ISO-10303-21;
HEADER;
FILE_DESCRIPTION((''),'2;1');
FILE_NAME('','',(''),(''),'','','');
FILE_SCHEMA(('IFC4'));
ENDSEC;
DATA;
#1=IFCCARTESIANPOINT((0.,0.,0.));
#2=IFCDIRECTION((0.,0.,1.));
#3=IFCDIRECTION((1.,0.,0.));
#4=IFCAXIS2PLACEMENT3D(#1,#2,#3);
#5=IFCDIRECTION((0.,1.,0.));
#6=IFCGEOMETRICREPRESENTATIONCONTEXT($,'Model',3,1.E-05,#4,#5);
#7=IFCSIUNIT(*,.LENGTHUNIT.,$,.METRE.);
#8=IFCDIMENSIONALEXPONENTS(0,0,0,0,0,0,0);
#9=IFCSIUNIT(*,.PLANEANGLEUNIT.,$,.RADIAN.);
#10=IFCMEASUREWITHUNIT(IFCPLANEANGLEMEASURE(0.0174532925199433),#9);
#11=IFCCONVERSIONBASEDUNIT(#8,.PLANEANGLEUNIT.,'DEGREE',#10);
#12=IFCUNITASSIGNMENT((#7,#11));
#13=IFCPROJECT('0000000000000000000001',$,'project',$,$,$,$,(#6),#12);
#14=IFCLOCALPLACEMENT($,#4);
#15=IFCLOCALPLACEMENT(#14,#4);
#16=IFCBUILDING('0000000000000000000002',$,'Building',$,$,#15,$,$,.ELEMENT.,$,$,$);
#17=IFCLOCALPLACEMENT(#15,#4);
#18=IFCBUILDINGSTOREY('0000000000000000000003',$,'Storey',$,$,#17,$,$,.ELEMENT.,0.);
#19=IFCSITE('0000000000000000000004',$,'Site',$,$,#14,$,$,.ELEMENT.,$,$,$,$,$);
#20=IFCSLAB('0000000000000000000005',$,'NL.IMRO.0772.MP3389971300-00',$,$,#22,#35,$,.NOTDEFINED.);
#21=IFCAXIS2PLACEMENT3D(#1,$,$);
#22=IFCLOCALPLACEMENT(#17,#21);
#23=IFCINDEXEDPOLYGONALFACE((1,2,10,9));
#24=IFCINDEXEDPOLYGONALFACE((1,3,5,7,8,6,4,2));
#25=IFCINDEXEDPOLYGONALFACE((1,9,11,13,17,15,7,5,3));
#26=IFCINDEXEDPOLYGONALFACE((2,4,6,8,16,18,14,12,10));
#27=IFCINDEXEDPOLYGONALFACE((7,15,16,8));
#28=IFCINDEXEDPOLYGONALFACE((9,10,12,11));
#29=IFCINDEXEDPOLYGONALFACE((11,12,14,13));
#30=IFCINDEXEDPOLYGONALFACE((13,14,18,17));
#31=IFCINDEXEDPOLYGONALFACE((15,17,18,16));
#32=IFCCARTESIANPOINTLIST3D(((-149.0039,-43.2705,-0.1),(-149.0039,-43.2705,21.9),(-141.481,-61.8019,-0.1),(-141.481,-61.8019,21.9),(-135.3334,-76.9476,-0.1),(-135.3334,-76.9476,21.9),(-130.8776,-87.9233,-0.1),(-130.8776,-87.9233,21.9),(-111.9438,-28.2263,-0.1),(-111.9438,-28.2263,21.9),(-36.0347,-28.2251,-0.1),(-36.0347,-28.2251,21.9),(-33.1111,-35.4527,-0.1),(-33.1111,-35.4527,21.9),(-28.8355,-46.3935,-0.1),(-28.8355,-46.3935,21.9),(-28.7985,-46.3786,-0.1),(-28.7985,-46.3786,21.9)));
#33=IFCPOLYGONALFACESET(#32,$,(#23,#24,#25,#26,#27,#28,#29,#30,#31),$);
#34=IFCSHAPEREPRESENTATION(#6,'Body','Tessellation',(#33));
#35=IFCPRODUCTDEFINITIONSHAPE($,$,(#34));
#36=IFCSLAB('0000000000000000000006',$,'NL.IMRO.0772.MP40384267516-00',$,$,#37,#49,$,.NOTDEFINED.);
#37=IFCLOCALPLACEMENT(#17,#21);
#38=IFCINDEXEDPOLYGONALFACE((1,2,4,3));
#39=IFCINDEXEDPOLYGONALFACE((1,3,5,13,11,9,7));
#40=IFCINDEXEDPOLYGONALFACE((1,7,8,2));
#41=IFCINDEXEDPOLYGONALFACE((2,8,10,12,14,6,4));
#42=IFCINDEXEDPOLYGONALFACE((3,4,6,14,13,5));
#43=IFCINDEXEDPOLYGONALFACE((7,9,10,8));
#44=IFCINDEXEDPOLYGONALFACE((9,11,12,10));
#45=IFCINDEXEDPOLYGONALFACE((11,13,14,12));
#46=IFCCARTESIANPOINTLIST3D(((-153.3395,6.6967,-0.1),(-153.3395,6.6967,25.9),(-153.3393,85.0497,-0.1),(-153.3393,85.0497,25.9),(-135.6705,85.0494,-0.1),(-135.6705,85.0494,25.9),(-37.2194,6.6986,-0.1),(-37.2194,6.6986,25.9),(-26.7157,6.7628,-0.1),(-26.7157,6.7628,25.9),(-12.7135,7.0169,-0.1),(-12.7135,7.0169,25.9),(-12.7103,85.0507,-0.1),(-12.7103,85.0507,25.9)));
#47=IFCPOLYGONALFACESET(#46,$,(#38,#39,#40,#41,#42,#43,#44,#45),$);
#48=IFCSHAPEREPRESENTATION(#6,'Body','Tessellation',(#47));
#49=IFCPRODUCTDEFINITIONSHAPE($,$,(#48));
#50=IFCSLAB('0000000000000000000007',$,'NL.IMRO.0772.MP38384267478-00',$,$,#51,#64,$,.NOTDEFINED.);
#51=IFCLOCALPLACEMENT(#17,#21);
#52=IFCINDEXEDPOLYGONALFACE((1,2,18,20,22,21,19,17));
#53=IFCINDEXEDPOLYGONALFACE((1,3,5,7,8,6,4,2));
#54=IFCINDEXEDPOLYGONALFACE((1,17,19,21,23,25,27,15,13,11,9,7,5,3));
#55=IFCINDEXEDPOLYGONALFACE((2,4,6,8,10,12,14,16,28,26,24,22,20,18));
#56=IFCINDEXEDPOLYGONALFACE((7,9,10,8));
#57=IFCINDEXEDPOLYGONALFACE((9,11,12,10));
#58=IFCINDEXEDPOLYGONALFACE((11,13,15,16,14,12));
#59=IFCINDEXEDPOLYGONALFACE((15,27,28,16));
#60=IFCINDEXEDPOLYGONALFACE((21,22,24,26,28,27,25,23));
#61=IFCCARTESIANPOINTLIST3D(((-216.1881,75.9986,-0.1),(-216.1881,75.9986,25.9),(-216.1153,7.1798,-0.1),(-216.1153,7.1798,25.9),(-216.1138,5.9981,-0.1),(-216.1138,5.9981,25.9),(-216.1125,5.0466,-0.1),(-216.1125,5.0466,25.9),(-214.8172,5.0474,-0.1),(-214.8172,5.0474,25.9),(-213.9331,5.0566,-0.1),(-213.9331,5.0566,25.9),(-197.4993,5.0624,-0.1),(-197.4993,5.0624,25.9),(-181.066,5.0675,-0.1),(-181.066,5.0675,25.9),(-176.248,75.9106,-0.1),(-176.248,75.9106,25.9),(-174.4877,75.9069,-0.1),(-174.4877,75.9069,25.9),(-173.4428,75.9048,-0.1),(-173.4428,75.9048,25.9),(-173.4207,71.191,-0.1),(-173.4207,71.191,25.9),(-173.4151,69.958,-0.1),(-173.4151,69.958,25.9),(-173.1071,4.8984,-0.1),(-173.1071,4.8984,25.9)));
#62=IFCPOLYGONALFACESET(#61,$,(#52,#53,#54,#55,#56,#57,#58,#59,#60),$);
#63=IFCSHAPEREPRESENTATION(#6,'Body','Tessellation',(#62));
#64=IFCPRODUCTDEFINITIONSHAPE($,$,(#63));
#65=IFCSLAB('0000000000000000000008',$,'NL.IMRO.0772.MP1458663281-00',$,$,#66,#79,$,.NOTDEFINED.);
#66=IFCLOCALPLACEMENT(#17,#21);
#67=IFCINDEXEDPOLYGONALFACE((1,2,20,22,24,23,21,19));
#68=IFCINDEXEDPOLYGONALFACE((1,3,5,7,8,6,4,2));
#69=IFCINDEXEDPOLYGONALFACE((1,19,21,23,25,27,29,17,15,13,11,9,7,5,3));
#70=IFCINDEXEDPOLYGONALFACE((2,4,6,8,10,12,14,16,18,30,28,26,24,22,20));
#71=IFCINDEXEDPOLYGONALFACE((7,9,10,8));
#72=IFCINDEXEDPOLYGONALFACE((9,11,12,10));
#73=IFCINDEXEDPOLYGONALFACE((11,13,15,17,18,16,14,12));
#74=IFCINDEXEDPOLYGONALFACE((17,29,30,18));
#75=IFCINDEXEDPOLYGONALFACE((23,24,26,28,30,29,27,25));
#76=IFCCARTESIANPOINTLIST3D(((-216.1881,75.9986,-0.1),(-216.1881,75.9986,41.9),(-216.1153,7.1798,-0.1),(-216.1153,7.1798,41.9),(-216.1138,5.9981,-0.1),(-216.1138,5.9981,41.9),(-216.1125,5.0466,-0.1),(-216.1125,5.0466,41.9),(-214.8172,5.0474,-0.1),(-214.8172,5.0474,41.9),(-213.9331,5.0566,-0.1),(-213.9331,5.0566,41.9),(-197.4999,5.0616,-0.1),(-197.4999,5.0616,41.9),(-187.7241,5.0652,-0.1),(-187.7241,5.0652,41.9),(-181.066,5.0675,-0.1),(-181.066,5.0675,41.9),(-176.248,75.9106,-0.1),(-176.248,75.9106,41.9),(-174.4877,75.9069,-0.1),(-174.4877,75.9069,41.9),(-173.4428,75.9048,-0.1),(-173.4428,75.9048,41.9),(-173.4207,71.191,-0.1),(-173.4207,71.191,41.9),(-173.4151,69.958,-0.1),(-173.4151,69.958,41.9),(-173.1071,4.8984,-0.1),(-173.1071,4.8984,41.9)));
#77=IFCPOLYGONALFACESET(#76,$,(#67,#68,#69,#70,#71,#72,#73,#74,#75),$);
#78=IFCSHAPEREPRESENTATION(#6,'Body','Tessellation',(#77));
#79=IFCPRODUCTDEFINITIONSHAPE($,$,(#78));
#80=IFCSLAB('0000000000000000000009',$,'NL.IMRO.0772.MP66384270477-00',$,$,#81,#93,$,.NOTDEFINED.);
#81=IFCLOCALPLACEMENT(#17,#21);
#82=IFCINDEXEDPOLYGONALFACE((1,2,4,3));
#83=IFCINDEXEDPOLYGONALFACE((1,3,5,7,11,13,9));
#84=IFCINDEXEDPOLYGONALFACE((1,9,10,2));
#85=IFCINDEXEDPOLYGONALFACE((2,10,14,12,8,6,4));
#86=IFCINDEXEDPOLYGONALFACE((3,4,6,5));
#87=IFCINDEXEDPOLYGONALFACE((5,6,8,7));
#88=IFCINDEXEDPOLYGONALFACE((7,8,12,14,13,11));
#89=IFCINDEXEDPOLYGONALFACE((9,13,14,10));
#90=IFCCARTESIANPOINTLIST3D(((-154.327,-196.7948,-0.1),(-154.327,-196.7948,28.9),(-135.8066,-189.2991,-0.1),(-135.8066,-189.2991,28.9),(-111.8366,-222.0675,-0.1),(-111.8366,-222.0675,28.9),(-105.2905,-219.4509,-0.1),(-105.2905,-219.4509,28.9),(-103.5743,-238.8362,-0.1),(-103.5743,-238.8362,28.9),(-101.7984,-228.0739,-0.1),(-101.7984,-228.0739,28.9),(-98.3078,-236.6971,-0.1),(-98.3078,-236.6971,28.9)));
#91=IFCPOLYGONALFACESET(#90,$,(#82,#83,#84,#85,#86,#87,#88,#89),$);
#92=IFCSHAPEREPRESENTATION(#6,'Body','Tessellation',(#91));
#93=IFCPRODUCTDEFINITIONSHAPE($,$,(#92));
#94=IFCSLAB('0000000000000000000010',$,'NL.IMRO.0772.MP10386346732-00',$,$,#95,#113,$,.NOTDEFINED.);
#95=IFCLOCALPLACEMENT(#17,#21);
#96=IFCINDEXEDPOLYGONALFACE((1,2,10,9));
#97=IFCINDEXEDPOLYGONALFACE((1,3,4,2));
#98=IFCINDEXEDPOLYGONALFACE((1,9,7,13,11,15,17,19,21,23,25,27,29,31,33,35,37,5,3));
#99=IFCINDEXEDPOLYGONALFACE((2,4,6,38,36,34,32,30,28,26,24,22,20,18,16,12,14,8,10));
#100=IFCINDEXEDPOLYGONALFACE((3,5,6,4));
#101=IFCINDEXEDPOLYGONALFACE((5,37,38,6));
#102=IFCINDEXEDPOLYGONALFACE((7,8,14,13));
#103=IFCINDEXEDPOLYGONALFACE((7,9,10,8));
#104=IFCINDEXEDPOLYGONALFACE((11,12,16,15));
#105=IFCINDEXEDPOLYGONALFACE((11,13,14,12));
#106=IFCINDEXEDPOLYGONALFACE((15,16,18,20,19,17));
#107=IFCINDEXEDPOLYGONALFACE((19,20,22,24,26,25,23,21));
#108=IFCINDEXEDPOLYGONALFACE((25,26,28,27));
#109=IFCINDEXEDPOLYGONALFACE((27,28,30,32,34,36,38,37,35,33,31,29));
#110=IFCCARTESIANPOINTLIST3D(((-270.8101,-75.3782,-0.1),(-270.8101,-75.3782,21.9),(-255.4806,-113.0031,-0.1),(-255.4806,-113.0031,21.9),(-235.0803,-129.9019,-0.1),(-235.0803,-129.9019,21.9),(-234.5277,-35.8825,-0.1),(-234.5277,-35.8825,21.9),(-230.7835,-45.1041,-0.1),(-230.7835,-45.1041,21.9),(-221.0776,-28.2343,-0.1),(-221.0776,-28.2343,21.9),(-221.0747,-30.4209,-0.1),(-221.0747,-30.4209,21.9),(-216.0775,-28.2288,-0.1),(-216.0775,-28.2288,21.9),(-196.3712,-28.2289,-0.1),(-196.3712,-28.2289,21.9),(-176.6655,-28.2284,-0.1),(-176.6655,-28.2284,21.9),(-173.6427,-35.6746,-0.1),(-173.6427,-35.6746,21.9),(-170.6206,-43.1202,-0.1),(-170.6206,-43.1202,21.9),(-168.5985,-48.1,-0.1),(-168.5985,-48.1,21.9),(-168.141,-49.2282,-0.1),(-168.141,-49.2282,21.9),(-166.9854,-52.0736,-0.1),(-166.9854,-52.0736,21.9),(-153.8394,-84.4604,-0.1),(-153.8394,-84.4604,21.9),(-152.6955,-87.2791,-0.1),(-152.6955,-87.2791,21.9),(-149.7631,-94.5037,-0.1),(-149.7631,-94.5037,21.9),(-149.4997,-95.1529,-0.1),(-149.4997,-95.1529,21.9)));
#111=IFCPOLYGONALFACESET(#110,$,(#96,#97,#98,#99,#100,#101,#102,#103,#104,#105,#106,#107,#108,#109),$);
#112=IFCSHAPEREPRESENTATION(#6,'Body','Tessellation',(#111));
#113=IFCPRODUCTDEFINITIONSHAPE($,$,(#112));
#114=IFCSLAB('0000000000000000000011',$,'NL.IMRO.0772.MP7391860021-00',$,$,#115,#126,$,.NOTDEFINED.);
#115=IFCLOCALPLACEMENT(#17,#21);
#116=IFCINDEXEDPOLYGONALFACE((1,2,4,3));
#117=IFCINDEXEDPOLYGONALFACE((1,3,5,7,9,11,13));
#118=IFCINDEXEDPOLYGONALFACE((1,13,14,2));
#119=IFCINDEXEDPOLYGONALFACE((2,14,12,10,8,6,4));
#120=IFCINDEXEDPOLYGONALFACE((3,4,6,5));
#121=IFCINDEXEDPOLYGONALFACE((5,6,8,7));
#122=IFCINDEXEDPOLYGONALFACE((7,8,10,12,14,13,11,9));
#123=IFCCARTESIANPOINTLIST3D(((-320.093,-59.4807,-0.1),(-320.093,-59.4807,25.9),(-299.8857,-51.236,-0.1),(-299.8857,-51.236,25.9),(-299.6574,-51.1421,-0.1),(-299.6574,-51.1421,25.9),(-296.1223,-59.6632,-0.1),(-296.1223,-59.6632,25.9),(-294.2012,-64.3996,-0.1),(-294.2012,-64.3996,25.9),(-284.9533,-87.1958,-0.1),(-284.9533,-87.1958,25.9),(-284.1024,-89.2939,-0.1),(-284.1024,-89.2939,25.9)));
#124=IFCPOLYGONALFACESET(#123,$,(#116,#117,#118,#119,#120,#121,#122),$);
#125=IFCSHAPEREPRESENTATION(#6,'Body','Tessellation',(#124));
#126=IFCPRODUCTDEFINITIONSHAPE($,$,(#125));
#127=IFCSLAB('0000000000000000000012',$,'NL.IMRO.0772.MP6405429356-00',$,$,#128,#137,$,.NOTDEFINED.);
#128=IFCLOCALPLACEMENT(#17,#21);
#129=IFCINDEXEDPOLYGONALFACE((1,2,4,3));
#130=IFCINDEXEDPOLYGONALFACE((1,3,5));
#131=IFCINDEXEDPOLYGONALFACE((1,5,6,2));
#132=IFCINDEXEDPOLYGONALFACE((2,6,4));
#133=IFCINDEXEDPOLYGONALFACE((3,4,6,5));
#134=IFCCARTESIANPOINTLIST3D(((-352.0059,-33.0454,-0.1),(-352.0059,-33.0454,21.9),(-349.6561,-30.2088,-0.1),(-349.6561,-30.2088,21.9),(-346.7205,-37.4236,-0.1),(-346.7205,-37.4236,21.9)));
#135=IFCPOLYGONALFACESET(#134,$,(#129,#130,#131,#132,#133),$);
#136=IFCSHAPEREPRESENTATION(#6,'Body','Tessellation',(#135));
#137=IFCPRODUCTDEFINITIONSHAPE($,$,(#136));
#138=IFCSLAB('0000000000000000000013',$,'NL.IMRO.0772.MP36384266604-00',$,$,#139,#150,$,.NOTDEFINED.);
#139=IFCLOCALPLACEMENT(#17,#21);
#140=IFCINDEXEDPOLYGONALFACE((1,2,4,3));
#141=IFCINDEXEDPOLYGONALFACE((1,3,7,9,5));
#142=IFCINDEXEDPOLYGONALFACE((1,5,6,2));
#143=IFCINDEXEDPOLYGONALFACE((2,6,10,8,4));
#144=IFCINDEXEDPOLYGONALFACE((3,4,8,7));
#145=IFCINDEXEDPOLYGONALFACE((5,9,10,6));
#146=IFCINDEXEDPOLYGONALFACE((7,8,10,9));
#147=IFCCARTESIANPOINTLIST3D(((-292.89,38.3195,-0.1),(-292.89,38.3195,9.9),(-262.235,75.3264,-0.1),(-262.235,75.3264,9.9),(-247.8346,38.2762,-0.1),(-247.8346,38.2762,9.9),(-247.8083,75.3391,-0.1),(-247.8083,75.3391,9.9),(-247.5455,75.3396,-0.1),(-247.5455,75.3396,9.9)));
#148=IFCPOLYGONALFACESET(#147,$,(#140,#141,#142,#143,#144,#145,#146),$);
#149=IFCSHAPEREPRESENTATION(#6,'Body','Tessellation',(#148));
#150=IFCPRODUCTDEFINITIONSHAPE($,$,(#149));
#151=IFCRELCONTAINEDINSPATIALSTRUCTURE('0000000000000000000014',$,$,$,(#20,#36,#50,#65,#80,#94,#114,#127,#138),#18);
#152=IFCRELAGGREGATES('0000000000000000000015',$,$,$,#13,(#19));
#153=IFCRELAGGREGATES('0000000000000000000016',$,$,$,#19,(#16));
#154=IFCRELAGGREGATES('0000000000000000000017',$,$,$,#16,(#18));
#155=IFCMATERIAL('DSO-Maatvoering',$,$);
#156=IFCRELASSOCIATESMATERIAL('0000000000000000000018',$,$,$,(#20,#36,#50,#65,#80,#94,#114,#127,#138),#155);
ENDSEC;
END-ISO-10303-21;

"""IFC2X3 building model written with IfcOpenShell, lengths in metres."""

from ifc_helpers import new_model, entity, si_unit, converted_unit, direction, frame, origin_with_axes, place, context, project, spatial, polyline, outline, extrude, material, element, save


model = new_model("IFC2X3")

# Units and contexts
model_context = context("Model", 3, precision=1e-05, world=origin_with_axes(), true_north=direction((0.0, 1.0, 0.0)))
ifc_project = project(units=[si_unit("LENGTHUNIT", "METRE"), converted_unit("PLANEANGLEUNIT", "DEGREE", entity("IfcPlaneAngleMeasure", 0.0174532925199433), si_unit("PLANEANGLEUNIT", "RADIAN"), dimensions=[0, 0, 0, 0, 0, 0, 0])], contexts=[model_context])

# Site, building, storey
site_placement = place(None, origin_with_axes())
site = spatial("IfcSite", under=ifc_project, at=site_placement, Name="Site", CompositionType="ELEMENT")
building_placement = place(site_placement, origin_with_axes())
building = spatial("IfcBuilding", under=site, at=building_placement, Name="Building", CompositionType="ELEMENT")
storey_placement = place(building_placement, origin_with_axes())
storey = spatial("IfcBuildingStorey", under=building, at=storey_placement, Name="Storey", CompositionType="ELEMENT", Elevation=0.0)

# Slabs
ifc_material = material(Name="DSO-Maatvoering")
slab_1_placement = place(storey_placement, frame((0.0, 0.0, -0.1), z_axis=(0.0, 0.0, 1.0), x_axis=(1.0, 0.0, 0.0)))
element("IfcSlab", 1, at=slab_1_placement, inside=storey, material=ifc_material, Name="NL.IMRO.0772.MP3389971300-00", PredefinedType="NOTDEFINED", context=model_context, shape_type="SweptSolid", body=[
    extrude(outline(polyline([(-28.7985, -46.3786), (-28.8355, -46.3935), (-130.8776, -87.9233), (-135.3334, -76.9476), (-141.481, -61.8019), (-149.0039, -43.2705), (-111.9438, -28.2263), (-36.0347, -28.2251), (-33.1111, -35.4527), (-28.7985, -46.3786)])), origin_with_axes(), (0.0, 0.0, 1.0), 22.0),
])
slab_2_placement = place(storey_placement, frame((0.0, 0.0, -0.1), z_axis=(0.0, 0.0, 1.0), x_axis=(1.0, 0.0, 0.0)))
element("IfcSlab", 2, at=slab_2_placement, inside=storey, material=ifc_material, Name="NL.IMRO.0772.MP40384267516-00", PredefinedType="NOTDEFINED", context=model_context, shape_type="SweptSolid", body=[
    extrude(outline(polyline([(-153.3393, 85.0497), (-135.6705, 85.0494), (-12.7103, 85.0507), (-12.7135, 7.0169), (-26.7157, 6.7628), (-37.2194, 6.6986), (-153.3395, 6.6967), (-153.3393, 85.0497)])), origin_with_axes(), (0.0, 0.0, 1.0), 26.0),
])
slab_3_placement = place(storey_placement, frame((0.0, 0.0, -0.1), z_axis=(0.0, 0.0, 1.0), x_axis=(1.0, 0.0, 0.0)))
element("IfcSlab", 3, at=slab_3_placement, inside=storey, material=ifc_material, Name="NL.IMRO.0772.MP38384267478-00", PredefinedType="NOTDEFINED", context=model_context, shape_type="SweptSolid", body=[
    extrude(outline(polyline([(-216.1138, 5.9981), (-216.1153, 7.1798), (-216.1881, 75.9986), (-176.248, 75.9106), (-174.4877, 75.9069), (-173.4428, 75.9048), (-173.4207, 71.191), (-173.4151, 69.958), (-173.1071, 4.8984), (-181.066, 5.0675), (-197.4993, 5.0624), (-213.9331, 5.0566), (-214.8172, 5.0474), (-216.1125, 5.0466), (-216.1138, 5.9981)])), origin_with_axes(), (0.0, 0.0, 1.0), 26.0),
])
slab_4_placement = place(storey_placement, frame((0.0, 0.0, -0.1), z_axis=(0.0, 0.0, 1.0), x_axis=(1.0, 0.0, 0.0)))
element("IfcSlab", 4, at=slab_4_placement, inside=storey, material=ifc_material, Name="NL.IMRO.0772.MP1458663281-00", PredefinedType="NOTDEFINED", context=model_context, shape_type="SweptSolid", body=[
    extrude(outline(polyline([(-187.7241, 5.0652), (-197.4999, 5.0616), (-213.9331, 5.0566), (-214.8172, 5.0474), (-216.1125, 5.0466), (-216.1138, 5.9981), (-216.1153, 7.1798), (-216.1881, 75.9986), (-176.248, 75.9106), (-174.4877, 75.9069), (-173.4428, 75.9048), (-173.4207, 71.191), (-173.4151, 69.958), (-173.1071, 4.8984), (-181.066, 5.0675), (-187.7241, 5.0652)])), origin_with_axes(), (0.0, 0.0, 1.0), 42.0),
])
slab_5_placement = place(storey_placement, frame((0.0, 0.0, -0.1), z_axis=(0.0, 0.0, 1.0), x_axis=(1.0, 0.0, 0.0)))
element("IfcSlab", 5, at=slab_5_placement, inside=storey, material=ifc_material, Name="NL.IMRO.0772.MP66384270477-00", PredefinedType="NOTDEFINED", context=model_context, shape_type="SweptSolid", body=[
    extrude(outline(polyline([(-135.8066, -189.2991), (-111.8366, -222.0675), (-105.2905, -219.4509), (-101.7984, -228.0739), (-98.3078, -236.6971), (-103.5743, -238.8362), (-154.327, -196.7948), (-135.8066, -189.2991)])), origin_with_axes(), (0.0, 0.0, 1.0), 29.0),
])
slab_6_placement = place(storey_placement, frame((0.0, 0.0, -0.1), z_axis=(0.0, 0.0, 1.0), x_axis=(1.0, 0.0, 0.0)))
element("IfcSlab", 6, at=slab_6_placement, inside=storey, material=ifc_material, Name="NL.IMRO.0772.MP10386346732-00", PredefinedType="NOTDEFINED", context=model_context, shape_type="SweptSolid", body=[
    extrude(outline(polyline([(-270.8101, -75.3782), (-230.7835, -45.1041), (-234.5277, -35.8825), (-221.0747, -30.4209), (-221.0776, -28.2343), (-216.0775, -28.2288), (-196.3712, -28.2289), (-176.6655, -28.2284), (-173.6427, -35.6746), (-170.6206, -43.1202), (-168.5985, -48.1), (-168.141, -49.2282), (-166.9854, -52.0736), (-153.8394, -84.4604), (-152.6955, -87.2791), (-149.7631, -94.5037), (-149.4997, -95.1529), (-235.0803, -129.9019), (-255.4806, -113.0031), (-270.8101, -75.3782)])), origin_with_axes(), (0.0, 0.0, 1.0), 22.0),
])
slab_7_placement = place(storey_placement, frame((0.0, 0.0, -0.1), z_axis=(0.0, 0.0, 1.0), x_axis=(1.0, 0.0, 0.0)))
element("IfcSlab", 7, at=slab_7_placement, inside=storey, material=ifc_material, Name="NL.IMRO.0772.MP7391860021-00", PredefinedType="NOTDEFINED", context=model_context, shape_type="SweptSolid", body=[
    extrude(outline(polyline([(-299.8857, -51.236), (-299.6574, -51.1421), (-296.1223, -59.6632), (-294.2012, -64.3996), (-284.9533, -87.1958), (-284.1024, -89.2939), (-320.093, -59.4807), (-299.8857, -51.236)])), origin_with_axes(), (0.0, 0.0, 1.0), 26.0),
])
slab_8_placement = place(storey_placement, frame((0.0, 0.0, -0.1), z_axis=(0.0, 0.0, 1.0), x_axis=(1.0, 0.0, 0.0)))
element("IfcSlab", 8, at=slab_8_placement, inside=storey, material=ifc_material, Name="NL.IMRO.0772.MP6405429356-00", PredefinedType="NOTDEFINED", context=model_context, shape_type="SweptSolid", body=[
    extrude(outline(polyline([(-346.7205, -37.4236), (-352.0059, -33.0454), (-349.6561, -30.2088), (-346.7205, -37.4236)])), origin_with_axes(), (0.0, 0.0, 1.0), 22.0),
])
slab_9_placement = place(storey_placement, frame((0.0, 0.0, -0.1), z_axis=(0.0, 0.0, 1.0), x_axis=(1.0, 0.0, 0.0)))
element("IfcSlab", 9, at=slab_9_placement, inside=storey, material=ifc_material, Name="NL.IMRO.0772.MP36384266604-00", PredefinedType="NOTDEFINED", context=model_context, shape_type="SweptSolid", body=[
    extrude(outline(polyline([(-247.8083, 75.3391), (-247.5455, 75.3396), (-247.8346, 38.2762), (-292.89, 38.3195), (-262.235, 75.3264), (-247.8083, 75.3391)])), origin_with_axes(), (0.0, 0.0, 1.0), 10.0),
])

save(model, "model.ifc")
